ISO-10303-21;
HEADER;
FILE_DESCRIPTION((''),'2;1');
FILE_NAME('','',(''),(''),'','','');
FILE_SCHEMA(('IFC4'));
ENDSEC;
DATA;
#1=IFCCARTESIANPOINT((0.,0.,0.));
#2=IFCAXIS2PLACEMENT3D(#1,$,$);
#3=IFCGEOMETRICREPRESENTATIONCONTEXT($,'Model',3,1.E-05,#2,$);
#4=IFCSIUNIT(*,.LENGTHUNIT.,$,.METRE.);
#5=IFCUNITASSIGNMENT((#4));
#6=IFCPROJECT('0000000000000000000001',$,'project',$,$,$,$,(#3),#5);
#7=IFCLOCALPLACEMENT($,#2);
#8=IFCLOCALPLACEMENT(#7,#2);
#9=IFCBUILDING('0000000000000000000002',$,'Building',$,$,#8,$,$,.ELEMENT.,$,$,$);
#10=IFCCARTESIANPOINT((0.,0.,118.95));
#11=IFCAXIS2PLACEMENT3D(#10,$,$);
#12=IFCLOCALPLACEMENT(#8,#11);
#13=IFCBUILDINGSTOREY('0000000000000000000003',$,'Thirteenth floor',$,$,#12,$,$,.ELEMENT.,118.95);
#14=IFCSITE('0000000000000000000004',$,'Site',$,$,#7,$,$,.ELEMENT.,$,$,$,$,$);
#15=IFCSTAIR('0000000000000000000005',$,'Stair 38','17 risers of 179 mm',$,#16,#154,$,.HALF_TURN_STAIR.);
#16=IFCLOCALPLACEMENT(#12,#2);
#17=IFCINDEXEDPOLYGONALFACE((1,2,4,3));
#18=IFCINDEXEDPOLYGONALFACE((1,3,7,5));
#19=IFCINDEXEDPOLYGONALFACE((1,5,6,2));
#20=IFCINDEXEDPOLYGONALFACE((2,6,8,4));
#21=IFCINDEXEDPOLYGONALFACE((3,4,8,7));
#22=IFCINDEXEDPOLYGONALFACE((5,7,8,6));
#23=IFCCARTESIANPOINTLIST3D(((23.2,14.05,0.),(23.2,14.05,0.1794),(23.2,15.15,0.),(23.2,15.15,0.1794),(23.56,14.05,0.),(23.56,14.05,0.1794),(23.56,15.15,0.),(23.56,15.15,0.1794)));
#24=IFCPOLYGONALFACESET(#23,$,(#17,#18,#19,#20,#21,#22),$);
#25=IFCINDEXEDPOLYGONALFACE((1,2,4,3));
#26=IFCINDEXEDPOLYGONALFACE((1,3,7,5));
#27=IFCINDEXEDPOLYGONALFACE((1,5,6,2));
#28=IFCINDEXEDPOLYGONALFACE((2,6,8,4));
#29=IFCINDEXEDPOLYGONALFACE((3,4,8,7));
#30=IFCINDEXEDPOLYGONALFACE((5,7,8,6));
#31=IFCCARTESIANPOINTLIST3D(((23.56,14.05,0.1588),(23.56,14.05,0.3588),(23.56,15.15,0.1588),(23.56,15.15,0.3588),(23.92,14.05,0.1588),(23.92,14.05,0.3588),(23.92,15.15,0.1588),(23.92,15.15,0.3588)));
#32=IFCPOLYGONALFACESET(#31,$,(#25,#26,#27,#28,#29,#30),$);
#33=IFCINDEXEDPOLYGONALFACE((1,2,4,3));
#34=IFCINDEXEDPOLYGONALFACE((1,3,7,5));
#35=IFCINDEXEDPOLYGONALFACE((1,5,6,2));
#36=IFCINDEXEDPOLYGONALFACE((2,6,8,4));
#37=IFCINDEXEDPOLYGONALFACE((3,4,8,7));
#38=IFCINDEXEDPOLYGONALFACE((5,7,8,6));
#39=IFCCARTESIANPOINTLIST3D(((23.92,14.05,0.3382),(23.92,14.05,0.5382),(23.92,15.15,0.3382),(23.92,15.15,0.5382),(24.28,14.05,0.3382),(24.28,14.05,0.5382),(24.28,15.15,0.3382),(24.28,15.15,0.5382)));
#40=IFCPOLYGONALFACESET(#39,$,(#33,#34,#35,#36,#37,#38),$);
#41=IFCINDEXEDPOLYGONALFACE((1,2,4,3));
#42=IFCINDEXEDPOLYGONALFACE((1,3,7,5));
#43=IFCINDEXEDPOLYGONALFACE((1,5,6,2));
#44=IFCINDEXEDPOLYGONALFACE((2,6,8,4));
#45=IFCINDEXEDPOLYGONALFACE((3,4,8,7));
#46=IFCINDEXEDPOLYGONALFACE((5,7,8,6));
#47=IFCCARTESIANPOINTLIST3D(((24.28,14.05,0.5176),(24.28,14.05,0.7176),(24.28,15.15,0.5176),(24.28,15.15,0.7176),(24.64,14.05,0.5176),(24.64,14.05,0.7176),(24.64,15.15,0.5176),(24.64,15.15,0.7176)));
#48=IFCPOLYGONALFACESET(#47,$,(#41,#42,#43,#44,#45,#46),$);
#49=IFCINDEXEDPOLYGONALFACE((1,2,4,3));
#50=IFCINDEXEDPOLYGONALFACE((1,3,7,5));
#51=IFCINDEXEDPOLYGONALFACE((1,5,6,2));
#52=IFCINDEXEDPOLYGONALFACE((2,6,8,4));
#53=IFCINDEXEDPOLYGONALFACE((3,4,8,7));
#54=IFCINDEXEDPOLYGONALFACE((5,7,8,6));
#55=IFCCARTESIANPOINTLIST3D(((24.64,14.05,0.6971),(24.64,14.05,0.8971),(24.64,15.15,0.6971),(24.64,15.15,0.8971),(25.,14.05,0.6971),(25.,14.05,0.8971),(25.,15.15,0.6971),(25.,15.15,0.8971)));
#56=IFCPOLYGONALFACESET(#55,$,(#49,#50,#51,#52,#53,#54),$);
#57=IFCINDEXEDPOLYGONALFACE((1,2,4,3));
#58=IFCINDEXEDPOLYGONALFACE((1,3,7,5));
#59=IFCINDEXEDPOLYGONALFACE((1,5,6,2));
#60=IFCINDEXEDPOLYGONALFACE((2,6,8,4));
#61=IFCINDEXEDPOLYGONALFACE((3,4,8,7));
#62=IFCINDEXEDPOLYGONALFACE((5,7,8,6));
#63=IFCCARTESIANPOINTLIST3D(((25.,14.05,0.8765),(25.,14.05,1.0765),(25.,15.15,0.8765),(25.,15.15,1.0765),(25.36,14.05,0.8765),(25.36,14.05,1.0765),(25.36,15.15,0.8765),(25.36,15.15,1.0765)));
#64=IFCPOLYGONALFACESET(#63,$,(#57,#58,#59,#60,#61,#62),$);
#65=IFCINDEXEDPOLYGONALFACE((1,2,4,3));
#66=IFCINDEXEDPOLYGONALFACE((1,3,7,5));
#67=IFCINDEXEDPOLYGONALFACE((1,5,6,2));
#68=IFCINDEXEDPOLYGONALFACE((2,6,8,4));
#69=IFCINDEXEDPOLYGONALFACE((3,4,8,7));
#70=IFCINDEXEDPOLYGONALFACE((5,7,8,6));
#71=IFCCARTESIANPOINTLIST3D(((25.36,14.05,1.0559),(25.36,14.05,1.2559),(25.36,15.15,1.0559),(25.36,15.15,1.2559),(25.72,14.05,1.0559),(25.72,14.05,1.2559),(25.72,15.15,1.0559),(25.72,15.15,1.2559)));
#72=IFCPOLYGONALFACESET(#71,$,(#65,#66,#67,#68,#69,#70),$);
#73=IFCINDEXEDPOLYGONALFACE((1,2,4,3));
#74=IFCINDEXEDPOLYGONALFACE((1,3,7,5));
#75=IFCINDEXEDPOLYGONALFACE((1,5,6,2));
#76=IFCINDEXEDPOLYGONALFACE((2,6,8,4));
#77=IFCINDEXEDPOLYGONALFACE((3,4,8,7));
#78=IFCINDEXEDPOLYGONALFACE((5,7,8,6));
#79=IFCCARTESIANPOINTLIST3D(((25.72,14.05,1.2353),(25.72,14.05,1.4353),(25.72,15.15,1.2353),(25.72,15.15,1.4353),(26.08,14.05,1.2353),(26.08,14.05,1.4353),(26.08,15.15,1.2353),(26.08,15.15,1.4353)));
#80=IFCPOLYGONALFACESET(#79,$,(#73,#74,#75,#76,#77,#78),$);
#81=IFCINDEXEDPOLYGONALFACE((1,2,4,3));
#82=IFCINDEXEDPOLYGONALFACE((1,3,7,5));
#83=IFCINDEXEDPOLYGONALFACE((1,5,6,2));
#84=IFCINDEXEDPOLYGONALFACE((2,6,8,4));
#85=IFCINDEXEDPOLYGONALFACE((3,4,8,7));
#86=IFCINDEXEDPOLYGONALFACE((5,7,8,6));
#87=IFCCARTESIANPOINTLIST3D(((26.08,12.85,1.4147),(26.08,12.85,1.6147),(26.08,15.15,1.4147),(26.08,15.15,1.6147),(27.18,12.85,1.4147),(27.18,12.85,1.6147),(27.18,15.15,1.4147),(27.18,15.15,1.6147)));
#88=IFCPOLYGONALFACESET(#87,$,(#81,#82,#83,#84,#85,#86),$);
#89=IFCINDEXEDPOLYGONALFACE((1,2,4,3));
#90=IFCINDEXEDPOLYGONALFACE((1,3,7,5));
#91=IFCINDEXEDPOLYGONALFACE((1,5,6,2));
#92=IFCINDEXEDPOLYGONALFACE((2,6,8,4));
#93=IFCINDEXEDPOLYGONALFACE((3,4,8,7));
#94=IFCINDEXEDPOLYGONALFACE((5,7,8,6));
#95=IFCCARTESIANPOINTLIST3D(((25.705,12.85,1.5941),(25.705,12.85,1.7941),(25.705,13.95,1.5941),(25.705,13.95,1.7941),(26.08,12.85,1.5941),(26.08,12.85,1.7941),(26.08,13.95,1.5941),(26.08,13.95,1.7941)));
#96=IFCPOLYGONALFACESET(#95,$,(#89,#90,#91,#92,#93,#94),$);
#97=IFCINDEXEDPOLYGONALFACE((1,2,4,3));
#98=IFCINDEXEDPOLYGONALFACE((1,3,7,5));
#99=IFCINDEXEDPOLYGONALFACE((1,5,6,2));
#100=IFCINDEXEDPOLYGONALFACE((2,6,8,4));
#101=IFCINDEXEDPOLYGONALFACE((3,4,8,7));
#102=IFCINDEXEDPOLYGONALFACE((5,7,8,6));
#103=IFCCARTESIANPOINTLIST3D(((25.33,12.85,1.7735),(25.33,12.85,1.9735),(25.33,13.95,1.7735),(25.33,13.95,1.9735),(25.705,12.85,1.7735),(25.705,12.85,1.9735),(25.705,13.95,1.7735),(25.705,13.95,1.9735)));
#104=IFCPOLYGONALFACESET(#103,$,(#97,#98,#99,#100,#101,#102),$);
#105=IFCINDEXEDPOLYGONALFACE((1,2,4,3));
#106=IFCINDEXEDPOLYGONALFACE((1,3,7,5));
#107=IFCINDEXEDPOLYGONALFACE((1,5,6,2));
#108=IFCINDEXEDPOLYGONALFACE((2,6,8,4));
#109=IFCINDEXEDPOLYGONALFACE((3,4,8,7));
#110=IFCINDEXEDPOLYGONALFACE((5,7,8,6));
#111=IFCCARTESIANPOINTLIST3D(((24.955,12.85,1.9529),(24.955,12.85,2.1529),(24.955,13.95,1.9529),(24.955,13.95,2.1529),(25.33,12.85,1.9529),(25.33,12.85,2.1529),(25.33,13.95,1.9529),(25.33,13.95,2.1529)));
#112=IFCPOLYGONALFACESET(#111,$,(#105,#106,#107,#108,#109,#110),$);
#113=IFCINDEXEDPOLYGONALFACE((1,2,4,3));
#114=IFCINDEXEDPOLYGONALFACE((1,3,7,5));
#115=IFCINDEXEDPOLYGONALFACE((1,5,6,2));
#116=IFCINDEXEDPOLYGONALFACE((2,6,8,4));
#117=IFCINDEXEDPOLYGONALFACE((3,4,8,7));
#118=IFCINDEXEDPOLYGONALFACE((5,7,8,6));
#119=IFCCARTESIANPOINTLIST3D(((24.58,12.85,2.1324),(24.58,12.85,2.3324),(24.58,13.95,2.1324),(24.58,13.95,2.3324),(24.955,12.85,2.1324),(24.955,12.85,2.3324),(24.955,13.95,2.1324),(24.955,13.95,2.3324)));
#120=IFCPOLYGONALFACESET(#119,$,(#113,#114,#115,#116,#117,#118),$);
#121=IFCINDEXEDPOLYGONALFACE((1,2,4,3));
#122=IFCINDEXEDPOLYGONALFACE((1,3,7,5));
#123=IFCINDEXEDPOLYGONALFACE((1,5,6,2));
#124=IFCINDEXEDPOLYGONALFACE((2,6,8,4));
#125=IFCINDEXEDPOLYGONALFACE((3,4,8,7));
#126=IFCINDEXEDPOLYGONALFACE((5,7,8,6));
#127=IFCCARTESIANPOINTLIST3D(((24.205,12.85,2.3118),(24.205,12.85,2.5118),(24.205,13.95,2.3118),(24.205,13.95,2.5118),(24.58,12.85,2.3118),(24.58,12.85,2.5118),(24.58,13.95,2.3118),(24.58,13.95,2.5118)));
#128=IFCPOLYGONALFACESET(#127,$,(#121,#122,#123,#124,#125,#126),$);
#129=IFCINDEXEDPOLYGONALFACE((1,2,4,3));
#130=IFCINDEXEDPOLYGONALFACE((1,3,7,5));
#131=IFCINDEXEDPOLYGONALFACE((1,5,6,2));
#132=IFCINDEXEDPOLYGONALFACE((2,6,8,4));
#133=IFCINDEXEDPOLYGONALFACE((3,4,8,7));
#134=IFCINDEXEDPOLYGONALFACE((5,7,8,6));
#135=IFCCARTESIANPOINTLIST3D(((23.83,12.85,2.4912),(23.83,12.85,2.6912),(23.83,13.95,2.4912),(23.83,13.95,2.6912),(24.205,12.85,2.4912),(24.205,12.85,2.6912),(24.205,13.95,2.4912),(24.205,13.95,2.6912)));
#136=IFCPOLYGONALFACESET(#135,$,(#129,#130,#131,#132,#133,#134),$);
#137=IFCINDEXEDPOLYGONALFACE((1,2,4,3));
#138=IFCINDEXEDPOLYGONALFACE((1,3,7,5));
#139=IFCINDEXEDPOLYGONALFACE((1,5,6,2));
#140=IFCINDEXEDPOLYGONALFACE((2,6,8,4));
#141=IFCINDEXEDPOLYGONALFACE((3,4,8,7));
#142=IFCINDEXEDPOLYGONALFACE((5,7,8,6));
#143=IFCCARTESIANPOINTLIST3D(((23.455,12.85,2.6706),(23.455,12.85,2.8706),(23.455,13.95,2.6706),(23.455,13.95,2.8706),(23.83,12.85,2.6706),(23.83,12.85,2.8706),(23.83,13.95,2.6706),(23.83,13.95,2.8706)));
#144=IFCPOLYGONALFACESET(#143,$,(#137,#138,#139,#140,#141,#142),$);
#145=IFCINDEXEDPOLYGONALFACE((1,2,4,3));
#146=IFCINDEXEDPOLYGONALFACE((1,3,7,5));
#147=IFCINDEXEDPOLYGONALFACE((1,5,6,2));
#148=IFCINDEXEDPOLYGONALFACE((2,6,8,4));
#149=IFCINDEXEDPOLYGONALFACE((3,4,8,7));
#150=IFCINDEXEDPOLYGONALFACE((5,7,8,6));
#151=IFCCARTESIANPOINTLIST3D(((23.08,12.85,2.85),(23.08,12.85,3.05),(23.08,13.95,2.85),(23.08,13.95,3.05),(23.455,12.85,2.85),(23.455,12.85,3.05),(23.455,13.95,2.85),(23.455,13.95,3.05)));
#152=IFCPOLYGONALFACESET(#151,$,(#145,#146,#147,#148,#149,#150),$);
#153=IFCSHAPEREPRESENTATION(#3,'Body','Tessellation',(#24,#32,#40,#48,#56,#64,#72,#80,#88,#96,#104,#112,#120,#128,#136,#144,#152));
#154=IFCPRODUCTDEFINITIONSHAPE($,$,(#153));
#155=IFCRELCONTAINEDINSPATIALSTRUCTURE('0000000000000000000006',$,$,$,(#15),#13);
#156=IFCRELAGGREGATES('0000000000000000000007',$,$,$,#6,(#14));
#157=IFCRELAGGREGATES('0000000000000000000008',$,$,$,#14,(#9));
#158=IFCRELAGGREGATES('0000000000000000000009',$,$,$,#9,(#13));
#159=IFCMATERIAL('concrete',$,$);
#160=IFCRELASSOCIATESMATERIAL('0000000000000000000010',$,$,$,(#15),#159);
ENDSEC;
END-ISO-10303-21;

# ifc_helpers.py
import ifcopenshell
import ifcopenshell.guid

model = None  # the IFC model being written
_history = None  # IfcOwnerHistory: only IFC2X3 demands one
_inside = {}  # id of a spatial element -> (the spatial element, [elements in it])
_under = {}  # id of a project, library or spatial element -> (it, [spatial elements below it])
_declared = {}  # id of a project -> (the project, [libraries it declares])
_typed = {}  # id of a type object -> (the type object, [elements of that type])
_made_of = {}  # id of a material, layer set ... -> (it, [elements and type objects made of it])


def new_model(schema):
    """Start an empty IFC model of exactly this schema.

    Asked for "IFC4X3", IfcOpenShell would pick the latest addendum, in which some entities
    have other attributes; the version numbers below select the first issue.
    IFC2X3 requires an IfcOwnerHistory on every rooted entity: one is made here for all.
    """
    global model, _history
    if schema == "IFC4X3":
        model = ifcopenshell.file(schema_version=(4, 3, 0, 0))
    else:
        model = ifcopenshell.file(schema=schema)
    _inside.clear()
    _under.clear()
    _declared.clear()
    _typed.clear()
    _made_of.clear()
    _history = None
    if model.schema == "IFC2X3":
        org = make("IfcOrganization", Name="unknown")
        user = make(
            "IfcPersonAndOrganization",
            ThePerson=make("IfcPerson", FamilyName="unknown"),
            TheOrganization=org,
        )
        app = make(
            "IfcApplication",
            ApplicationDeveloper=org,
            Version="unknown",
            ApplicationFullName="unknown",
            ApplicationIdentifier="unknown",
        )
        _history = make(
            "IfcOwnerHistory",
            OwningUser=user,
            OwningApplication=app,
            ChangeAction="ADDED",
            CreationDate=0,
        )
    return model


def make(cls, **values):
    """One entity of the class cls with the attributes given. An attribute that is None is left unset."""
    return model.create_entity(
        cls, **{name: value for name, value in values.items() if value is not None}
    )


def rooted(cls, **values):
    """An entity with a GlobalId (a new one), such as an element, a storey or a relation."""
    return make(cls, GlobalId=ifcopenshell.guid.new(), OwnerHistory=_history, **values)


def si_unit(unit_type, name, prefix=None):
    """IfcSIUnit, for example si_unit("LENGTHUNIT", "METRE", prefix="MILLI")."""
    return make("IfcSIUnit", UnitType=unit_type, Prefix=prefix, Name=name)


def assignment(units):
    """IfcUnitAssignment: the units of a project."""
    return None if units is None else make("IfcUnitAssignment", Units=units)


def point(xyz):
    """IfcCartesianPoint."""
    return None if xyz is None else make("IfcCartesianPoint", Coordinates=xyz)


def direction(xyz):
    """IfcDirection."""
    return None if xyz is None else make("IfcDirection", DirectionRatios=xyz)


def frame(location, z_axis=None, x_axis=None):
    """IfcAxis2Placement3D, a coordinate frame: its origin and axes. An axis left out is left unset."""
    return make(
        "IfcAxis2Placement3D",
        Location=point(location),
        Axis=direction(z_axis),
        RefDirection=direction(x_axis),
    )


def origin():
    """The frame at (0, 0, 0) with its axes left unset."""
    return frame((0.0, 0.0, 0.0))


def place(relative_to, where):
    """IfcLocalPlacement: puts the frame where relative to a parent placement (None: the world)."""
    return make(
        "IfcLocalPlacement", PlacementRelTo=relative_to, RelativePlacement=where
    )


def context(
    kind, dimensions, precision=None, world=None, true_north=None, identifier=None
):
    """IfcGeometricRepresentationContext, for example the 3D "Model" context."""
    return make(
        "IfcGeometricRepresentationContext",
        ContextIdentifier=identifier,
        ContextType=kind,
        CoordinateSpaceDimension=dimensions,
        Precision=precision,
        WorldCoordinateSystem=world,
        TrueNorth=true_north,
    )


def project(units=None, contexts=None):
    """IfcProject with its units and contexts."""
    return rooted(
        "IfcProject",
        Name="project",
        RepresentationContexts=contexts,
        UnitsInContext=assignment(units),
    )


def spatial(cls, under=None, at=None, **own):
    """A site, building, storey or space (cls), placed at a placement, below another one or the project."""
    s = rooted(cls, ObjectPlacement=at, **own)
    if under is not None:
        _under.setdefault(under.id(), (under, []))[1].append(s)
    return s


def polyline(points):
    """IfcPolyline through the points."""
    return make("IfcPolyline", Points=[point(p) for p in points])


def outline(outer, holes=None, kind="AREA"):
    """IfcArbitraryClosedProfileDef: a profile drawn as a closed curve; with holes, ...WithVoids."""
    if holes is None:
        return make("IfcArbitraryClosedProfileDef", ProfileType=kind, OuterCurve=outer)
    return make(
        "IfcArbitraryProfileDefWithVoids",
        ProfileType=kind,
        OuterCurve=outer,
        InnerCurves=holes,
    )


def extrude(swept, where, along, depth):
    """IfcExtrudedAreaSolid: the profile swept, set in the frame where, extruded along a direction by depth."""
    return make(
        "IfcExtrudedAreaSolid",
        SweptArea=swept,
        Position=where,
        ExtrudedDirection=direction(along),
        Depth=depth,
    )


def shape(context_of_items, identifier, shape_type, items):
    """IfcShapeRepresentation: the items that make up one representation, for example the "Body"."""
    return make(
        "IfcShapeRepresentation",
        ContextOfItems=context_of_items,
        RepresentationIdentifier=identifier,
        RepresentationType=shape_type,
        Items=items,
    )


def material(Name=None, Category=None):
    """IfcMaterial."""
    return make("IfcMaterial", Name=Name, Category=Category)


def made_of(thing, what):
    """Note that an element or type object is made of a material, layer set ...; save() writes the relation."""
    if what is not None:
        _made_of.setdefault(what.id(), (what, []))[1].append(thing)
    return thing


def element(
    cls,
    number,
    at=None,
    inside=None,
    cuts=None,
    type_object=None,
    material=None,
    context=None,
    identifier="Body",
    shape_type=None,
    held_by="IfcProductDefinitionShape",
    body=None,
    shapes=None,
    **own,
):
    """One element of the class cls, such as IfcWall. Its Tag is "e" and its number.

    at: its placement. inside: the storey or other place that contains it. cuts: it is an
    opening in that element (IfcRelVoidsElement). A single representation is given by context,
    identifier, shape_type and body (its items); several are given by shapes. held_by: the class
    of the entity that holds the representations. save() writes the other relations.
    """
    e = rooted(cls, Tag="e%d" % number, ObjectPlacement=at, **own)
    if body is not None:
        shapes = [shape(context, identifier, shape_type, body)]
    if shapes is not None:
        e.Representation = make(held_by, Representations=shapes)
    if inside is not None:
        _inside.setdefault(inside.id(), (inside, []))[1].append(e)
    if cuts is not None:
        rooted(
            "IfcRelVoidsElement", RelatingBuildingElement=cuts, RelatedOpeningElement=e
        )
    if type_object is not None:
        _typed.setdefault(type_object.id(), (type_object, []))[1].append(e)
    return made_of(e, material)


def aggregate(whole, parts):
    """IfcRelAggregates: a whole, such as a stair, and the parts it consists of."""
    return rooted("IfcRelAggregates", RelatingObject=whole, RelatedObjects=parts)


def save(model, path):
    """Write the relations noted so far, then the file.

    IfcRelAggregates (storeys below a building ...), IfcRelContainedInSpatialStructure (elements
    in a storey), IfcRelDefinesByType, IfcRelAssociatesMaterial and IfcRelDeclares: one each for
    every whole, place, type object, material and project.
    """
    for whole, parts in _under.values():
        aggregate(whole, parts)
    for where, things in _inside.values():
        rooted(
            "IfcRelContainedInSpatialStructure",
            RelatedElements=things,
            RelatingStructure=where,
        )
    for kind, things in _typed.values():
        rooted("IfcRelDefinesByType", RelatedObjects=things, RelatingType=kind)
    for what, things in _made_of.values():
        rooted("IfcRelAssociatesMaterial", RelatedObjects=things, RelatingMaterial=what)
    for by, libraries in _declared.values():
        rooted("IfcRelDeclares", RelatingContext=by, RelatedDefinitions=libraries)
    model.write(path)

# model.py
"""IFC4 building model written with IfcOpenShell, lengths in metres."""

from ifc_helpers import new_model, si_unit, frame, origin, place, context, project, spatial, polyline, outline, extrude, material, element, save


model = new_model("IFC4")

# Units and contexts
model_context = context("Model", 3, precision=1e-05, world=origin())
ifc_project = project(units=[si_unit("LENGTHUNIT", "METRE")], contexts=[model_context])

# Site, building, storey
site_placement = place(None, origin())
site = spatial("IfcSite", under=ifc_project, at=site_placement, Name="Site", CompositionType="ELEMENT")
building_placement = place(site_placement, origin())
building = spatial("IfcBuilding", under=site, at=building_placement, Name="Building", CompositionType="ELEMENT")
storey_placement = place(building_placement, frame((0.0, 0.0, 118.95)))
storey = spatial("IfcBuildingStorey", under=building, at=storey_placement, Name="Thirteenth floor", CompositionType="ELEMENT", Elevation=118.95)

# Shared definitions
ifc_material = material(Name="concrete")

# Stair
stair_placement = place(storey_placement, frame((23.2, 14.6, 0.0), z_axis=(0.0, 0.0, 1.0), x_axis=(1.0, 0.0, 0.0)))
element("IfcStair", 1, at=stair_placement, inside=storey, material=ifc_material, Name="Stair 38", Description="17 risers of 179 mm", PredefinedType="HALF_TURN_STAIR", context=model_context, shape_type="SweptSolid", body=[
    extrude(outline(polyline([(0.0, -0.55), (0.36, -0.55), (0.36, 0.55), (0.0, 0.55), (0.0, -0.55)])), origin(), (0.0, 0.0, 1.0), 0.1794),
    extrude(outline(polyline([(0.36, -0.55), (0.72, -0.55), (0.72, 0.55), (0.36, 0.55), (0.36, -0.55)])), frame((0.0, 0.0, 0.1588)), (0.0, 0.0, 1.0), 0.2),
    extrude(outline(polyline([(0.72, -0.55), (1.08, -0.55), (1.08, 0.55), (0.72, 0.55), (0.72, -0.55)])), frame((0.0, 0.0, 0.3382)), (0.0, 0.0, 1.0), 0.2),
    extrude(outline(polyline([(1.08, -0.55), (1.44, -0.55), (1.44, 0.55), (1.08, 0.55), (1.08, -0.55)])), frame((0.0, 0.0, 0.5176)), (0.0, 0.0, 1.0), 0.2),
    extrude(outline(polyline([(1.44, -0.55), (1.8, -0.55), (1.8, 0.55), (1.44, 0.55), (1.44, -0.55)])), frame((0.0, 0.0, 0.6971)), (0.0, 0.0, 1.0), 0.2),
    extrude(outline(polyline([(1.8, -0.55), (2.16, -0.55), (2.16, 0.55), (1.8, 0.55), (1.8, -0.55)])), frame((0.0, 0.0, 0.8765)), (0.0, 0.0, 1.0), 0.2),
    extrude(outline(polyline([(2.16, -0.55), (2.52, -0.55), (2.52, 0.55), (2.16, 0.55), (2.16, -0.55)])), frame((0.0, 0.0, 1.0559)), (0.0, 0.0, 1.0), 0.2),
    extrude(outline(polyline([(2.52, -0.55), (2.88, -0.55), (2.88, 0.55), (2.52, 0.55), (2.52, -0.55)])), frame((0.0, 0.0, 1.2353)), (0.0, 0.0, 1.0), 0.2),
    extrude(outline(polyline([(2.88, -1.75), (3.98, -1.75), (3.98, 0.55), (2.88, 0.55), (2.88, -1.75)])), frame((0.0, 0.0, 1.4147)), (0.0, 0.0, 1.0), 0.2),
    extrude(outline(polyline([(2.505, -1.75), (2.88, -1.75), (2.88, -0.65), (2.505, -0.65), (2.505, -1.75)])), frame((0.0, 0.0, 1.5941)), (0.0, 0.0, 1.0), 0.2),
    extrude(outline(polyline([(2.13, -1.75), (2.505, -1.75), (2.505, -0.65), (2.13, -0.65), (2.13, -1.75)])), frame((0.0, 0.0, 1.7735)), (0.0, 0.0, 1.0), 0.2),
    extrude(outline(polyline([(1.755, -1.75), (2.13, -1.75), (2.13, -0.65), (1.755, -0.65), (1.755, -1.75)])), frame((0.0, 0.0, 1.9529)), (0.0, 0.0, 1.0), 0.2),
    extrude(outline(polyline([(1.38, -1.75), (1.755, -1.75), (1.755, -0.65), (1.38, -0.65), (1.38, -1.75)])), frame((0.0, 0.0, 2.1324)), (0.0, 0.0, 1.0), 0.2),
    extrude(outline(polyline([(1.005, -1.75), (1.38, -1.75), (1.38, -0.65), (1.005, -0.65), (1.005, -1.75)])), frame((0.0, 0.0, 2.3118)), (0.0, 0.0, 1.0), 0.2),
    extrude(outline(polyline([(0.63, -1.75), (1.005, -1.75), (1.005, -0.65), (0.63, -0.65), (0.63, -1.75)])), frame((0.0, 0.0, 2.4912)), (0.0, 0.0, 1.0), 0.2),
    extrude(outline(polyline([(0.255, -1.75), (0.63, -1.75), (0.63, -0.65), (0.255, -0.65), (0.255, -1.75)])), frame((0.0, 0.0, 2.6706)), (0.0, 0.0, 1.0), 0.2),
    extrude(outline(polyline([(-0.12, -1.75), (0.255, -1.75), (0.255, -0.65), (-0.12, -0.65), (-0.12, -1.75)])), frame((0.0, 0.0, 2.85)), (0.0, 0.0, 1.0), 0.2),
])

save(model, "model.ifc")
